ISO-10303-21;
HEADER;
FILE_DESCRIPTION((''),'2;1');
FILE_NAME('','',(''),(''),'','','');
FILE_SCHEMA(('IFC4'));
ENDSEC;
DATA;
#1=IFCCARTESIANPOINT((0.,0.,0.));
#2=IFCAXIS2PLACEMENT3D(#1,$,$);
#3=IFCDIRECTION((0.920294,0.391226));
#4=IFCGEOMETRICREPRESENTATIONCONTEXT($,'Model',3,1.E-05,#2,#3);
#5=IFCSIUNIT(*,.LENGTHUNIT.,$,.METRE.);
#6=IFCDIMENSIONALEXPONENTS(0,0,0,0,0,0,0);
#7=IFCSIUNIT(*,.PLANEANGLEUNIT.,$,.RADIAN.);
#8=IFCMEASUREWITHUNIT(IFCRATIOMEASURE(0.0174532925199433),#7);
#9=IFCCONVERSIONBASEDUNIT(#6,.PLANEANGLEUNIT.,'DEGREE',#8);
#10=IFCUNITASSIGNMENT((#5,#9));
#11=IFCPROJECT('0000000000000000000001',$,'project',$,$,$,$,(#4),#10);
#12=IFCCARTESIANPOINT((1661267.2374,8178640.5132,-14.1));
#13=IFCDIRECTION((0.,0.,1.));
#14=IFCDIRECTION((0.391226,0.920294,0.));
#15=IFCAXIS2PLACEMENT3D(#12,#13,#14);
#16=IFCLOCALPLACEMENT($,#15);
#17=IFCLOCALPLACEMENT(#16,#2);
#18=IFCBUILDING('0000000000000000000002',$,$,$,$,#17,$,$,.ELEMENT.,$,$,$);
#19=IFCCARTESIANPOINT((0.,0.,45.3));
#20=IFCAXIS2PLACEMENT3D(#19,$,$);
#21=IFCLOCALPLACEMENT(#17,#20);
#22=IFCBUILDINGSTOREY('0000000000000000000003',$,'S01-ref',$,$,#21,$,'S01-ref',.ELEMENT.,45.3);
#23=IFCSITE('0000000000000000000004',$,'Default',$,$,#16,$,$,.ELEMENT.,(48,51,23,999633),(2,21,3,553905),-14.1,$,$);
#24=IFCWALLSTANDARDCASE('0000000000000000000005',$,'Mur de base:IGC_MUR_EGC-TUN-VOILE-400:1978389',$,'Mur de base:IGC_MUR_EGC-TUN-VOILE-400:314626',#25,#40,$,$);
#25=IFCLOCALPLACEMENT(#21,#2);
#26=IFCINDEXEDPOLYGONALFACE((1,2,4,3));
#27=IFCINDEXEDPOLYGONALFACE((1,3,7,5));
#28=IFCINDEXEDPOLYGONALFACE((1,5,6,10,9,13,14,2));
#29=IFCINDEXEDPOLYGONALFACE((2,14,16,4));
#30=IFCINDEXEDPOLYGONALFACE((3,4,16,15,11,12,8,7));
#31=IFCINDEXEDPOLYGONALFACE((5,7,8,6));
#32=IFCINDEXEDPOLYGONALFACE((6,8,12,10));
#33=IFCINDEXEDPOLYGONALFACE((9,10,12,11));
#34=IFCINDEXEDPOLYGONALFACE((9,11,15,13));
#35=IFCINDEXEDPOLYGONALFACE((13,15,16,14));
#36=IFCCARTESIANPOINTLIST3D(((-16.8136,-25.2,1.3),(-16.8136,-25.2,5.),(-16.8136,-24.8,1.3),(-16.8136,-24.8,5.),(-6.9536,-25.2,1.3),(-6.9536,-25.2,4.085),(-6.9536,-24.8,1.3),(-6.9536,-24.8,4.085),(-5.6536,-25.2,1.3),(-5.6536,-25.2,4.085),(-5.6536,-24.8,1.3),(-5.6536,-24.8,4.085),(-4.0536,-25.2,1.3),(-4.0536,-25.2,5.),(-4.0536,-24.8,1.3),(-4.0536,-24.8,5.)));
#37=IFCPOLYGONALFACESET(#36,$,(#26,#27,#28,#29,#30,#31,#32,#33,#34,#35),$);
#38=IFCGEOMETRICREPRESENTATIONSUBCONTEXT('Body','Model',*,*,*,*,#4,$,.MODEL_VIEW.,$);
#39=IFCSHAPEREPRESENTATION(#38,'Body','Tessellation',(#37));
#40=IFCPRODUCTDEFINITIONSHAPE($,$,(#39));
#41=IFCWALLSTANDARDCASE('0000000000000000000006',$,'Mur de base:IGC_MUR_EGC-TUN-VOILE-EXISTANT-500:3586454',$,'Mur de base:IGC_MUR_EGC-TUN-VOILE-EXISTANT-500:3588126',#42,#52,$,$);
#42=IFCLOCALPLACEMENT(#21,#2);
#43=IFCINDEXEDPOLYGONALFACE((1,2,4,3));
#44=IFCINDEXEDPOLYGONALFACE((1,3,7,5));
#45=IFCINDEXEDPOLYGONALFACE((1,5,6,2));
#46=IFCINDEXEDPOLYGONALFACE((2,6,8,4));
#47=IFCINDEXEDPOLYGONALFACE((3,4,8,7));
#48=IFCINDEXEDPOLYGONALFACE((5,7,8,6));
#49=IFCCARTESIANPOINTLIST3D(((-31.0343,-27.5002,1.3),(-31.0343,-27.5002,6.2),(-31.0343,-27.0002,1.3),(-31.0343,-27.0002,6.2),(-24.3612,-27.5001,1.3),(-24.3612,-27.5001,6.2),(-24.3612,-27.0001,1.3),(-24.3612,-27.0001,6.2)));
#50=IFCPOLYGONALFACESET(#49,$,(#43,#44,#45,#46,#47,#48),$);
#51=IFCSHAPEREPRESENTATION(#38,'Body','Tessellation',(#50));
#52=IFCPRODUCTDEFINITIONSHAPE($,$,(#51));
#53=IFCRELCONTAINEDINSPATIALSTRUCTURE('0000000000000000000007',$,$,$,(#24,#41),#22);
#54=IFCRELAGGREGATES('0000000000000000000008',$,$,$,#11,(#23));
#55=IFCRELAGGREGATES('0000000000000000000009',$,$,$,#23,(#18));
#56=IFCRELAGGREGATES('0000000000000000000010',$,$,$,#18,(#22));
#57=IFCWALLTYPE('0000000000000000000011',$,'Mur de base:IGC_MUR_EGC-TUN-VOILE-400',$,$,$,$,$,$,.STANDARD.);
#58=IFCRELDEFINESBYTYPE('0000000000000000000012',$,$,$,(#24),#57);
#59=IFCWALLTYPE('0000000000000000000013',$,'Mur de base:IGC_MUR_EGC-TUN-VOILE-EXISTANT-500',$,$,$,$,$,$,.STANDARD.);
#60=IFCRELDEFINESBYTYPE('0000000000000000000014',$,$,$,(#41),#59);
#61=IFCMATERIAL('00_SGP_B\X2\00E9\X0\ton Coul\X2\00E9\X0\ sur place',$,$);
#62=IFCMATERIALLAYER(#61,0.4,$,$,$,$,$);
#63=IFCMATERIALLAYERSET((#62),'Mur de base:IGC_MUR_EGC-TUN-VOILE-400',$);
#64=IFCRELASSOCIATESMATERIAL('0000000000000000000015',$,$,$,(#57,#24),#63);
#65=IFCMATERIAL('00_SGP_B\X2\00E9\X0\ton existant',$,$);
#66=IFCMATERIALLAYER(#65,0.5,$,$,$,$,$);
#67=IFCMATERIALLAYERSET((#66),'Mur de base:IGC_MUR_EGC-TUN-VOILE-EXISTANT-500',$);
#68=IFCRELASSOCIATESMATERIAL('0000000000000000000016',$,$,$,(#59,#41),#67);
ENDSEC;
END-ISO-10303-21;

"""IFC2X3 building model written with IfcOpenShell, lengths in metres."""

from ifc_helpers import new_model, entity, si_unit, converted_unit, direction, frame, frame_2d, origin, place, context, subcontext, project, spatial, polyline, rectangle, extrude, clip, bounded_halfspace, material, layer, layer_set, layer_usage, type_object, element, save


model = new_model("IFC2X3")

# Units and contexts
model_context = context("Model", 3, precision=1e-05, world=origin(), true_north=direction((0.920294, 0.391226)))
body_context = subcontext(model_context, "Body", "Model", "MODEL_VIEW")
ifc_project = project(units=[si_unit("LENGTHUNIT", "METRE"), converted_unit("PLANEANGLEUNIT", "DEGREE", entity("IfcRatioMeasure", 0.0174532925199433), si_unit("PLANEANGLEUNIT", "RADIAN"), dimensions=[0, 0, 0, 0, 0, 0, 0])], contexts=[model_context])

# Site, building, storey
site_placement = place(None, frame((1661267.2374, 8178640.5132, -14.1), z_axis=(0.0, 0.0, 1.0), x_axis=(0.391226, 0.920294, 0.0)))
site = spatial("IfcSite", under=ifc_project, at=site_placement, Name="Default", CompositionType="ELEMENT", RefLatitude=(48, 51, 23, 999633), RefLongitude=(2, 21, 3, 553905), RefElevation=-14.1)
building_placement = place(site_placement, origin())
building = spatial("IfcBuilding", under=site, at=building_placement, CompositionType="ELEMENT")
storey_placement = place(building_placement, frame((0.0, 0.0, 45.3)))
storey = spatial("IfcBuildingStorey", under=building, at=storey_placement, Name="S01-ref", LongName="S01-ref", CompositionType="ELEMENT", Elevation=45.3)

# Shared definitions
ifc_material_1 = material(Name="00_SGP_Béton Coulé sur place")

# Shared definitions
ifc_layer_1 = layer(ifc_material_1, 0.4)
ifc_layer_set_1 = layer_set([ifc_layer_1], Name="Mur de base:IGC_MUR_EGC-TUN-VOILE-400")
wall_type_1 = type_object("IfcWallType", Name="Mur de base:IGC_MUR_EGC-TUN-VOILE-400", PredefinedType="STANDARD", material=ifc_layer_set_1)

# Wall, opening
ifc_layer_usage_1 = layer_usage(ifc_layer_set_1, "AXIS2", "NEGATIVE", 0.2)
wall_1_placement = place(storey_placement, frame((-16.8136, -25.0, 1.3)))
wall_1 = element("IfcWallStandardCase", 1, at=wall_1_placement, inside=storey, type_object=wall_type_1, material=ifc_layer_usage_1, Name="Mur de base:IGC_MUR_EGC-TUN-VOILE-400:1978389", ObjectType="Mur de base:IGC_MUR_EGC-TUN-VOILE-400:314626", context=body_context, shape_type="Clipping", body=[
    clip(extrude(rectangle(XDim=12.76, YDim=0.4, at=frame_2d((6.38, 0.0), x_axis=(-1.0, 0.0))), origin(), (0.0, 0.0, 1.0), 3.7), bounded_halfspace(frame((0.0, -0.2, 3.7), z_axis=(0.0, 0.0, -1.0), x_axis=(0.144304, 0.989533, 0.0)), True, frame((0.0, -0.2, 3.7)), polyline([(0.0, 0.0), (12.76, 0.0), (12.76, 0.4), (0.0, 0.4), (0.0, 0.0)]))),
])
opening_1_placement = place(wall_1_placement, origin())
element("IfcOpeningElement", 2, at=opening_1_placement, cuts=wall_1, ObjectType="Opening", context=body_context, shape_type="SweptSolid", body=[
    extrude(rectangle(XDim=2.785, YDim=1.3, at=frame_2d((0.0, 0.0), x_axis=(0.0, 1.0))), frame((10.51, -1.724, 1.3925), z_axis=(0.0, 1.0, 0.0), x_axis=(1.0, 0.0, 0.0)), (0.0, 0.0, 1.0), 3.048),
])

# Wall
ifc_material_2 = material(Name="00_SGP_Béton existant")
ifc_layer_2 = layer(ifc_material_2, 0.5)
ifc_layer_set_2 = layer_set([ifc_layer_2], Name="Mur de base:IGC_MUR_EGC-TUN-VOILE-EXISTANT-500")
ifc_layer_usage_2 = layer_usage(ifc_layer_set_2, "AXIS2", "NEGATIVE", 0.25)
wall_type_2 = type_object("IfcWallType", Name="Mur de base:IGC_MUR_EGC-TUN-VOILE-EXISTANT-500", PredefinedType="STANDARD", material=ifc_layer_set_2)
wall_2_placement = place(storey_placement, frame((-24.3612, -27.2501, 1.3), z_axis=(0.0, 0.0, 1.0), x_axis=(-1.0, -0.000011, 0.0)))
element("IfcWallStandardCase", 3, at=wall_2_placement, inside=storey, type_object=wall_type_2, material=ifc_layer_usage_2, Name="Mur de base:IGC_MUR_EGC-TUN-VOILE-EXISTANT-500:3586454", ObjectType="Mur de base:IGC_MUR_EGC-TUN-VOILE-EXISTANT-500:3588126", context=body_context, shape_type="SweptSolid", body=[
    extrude(rectangle(XDim=6.6731, YDim=0.5, at=frame_2d((3.3366, 0.0), x_axis=(-1.0, 0.0))), origin(), (0.0, 0.0, 1.0), 4.9),
])

save(model, "model.ifc")
